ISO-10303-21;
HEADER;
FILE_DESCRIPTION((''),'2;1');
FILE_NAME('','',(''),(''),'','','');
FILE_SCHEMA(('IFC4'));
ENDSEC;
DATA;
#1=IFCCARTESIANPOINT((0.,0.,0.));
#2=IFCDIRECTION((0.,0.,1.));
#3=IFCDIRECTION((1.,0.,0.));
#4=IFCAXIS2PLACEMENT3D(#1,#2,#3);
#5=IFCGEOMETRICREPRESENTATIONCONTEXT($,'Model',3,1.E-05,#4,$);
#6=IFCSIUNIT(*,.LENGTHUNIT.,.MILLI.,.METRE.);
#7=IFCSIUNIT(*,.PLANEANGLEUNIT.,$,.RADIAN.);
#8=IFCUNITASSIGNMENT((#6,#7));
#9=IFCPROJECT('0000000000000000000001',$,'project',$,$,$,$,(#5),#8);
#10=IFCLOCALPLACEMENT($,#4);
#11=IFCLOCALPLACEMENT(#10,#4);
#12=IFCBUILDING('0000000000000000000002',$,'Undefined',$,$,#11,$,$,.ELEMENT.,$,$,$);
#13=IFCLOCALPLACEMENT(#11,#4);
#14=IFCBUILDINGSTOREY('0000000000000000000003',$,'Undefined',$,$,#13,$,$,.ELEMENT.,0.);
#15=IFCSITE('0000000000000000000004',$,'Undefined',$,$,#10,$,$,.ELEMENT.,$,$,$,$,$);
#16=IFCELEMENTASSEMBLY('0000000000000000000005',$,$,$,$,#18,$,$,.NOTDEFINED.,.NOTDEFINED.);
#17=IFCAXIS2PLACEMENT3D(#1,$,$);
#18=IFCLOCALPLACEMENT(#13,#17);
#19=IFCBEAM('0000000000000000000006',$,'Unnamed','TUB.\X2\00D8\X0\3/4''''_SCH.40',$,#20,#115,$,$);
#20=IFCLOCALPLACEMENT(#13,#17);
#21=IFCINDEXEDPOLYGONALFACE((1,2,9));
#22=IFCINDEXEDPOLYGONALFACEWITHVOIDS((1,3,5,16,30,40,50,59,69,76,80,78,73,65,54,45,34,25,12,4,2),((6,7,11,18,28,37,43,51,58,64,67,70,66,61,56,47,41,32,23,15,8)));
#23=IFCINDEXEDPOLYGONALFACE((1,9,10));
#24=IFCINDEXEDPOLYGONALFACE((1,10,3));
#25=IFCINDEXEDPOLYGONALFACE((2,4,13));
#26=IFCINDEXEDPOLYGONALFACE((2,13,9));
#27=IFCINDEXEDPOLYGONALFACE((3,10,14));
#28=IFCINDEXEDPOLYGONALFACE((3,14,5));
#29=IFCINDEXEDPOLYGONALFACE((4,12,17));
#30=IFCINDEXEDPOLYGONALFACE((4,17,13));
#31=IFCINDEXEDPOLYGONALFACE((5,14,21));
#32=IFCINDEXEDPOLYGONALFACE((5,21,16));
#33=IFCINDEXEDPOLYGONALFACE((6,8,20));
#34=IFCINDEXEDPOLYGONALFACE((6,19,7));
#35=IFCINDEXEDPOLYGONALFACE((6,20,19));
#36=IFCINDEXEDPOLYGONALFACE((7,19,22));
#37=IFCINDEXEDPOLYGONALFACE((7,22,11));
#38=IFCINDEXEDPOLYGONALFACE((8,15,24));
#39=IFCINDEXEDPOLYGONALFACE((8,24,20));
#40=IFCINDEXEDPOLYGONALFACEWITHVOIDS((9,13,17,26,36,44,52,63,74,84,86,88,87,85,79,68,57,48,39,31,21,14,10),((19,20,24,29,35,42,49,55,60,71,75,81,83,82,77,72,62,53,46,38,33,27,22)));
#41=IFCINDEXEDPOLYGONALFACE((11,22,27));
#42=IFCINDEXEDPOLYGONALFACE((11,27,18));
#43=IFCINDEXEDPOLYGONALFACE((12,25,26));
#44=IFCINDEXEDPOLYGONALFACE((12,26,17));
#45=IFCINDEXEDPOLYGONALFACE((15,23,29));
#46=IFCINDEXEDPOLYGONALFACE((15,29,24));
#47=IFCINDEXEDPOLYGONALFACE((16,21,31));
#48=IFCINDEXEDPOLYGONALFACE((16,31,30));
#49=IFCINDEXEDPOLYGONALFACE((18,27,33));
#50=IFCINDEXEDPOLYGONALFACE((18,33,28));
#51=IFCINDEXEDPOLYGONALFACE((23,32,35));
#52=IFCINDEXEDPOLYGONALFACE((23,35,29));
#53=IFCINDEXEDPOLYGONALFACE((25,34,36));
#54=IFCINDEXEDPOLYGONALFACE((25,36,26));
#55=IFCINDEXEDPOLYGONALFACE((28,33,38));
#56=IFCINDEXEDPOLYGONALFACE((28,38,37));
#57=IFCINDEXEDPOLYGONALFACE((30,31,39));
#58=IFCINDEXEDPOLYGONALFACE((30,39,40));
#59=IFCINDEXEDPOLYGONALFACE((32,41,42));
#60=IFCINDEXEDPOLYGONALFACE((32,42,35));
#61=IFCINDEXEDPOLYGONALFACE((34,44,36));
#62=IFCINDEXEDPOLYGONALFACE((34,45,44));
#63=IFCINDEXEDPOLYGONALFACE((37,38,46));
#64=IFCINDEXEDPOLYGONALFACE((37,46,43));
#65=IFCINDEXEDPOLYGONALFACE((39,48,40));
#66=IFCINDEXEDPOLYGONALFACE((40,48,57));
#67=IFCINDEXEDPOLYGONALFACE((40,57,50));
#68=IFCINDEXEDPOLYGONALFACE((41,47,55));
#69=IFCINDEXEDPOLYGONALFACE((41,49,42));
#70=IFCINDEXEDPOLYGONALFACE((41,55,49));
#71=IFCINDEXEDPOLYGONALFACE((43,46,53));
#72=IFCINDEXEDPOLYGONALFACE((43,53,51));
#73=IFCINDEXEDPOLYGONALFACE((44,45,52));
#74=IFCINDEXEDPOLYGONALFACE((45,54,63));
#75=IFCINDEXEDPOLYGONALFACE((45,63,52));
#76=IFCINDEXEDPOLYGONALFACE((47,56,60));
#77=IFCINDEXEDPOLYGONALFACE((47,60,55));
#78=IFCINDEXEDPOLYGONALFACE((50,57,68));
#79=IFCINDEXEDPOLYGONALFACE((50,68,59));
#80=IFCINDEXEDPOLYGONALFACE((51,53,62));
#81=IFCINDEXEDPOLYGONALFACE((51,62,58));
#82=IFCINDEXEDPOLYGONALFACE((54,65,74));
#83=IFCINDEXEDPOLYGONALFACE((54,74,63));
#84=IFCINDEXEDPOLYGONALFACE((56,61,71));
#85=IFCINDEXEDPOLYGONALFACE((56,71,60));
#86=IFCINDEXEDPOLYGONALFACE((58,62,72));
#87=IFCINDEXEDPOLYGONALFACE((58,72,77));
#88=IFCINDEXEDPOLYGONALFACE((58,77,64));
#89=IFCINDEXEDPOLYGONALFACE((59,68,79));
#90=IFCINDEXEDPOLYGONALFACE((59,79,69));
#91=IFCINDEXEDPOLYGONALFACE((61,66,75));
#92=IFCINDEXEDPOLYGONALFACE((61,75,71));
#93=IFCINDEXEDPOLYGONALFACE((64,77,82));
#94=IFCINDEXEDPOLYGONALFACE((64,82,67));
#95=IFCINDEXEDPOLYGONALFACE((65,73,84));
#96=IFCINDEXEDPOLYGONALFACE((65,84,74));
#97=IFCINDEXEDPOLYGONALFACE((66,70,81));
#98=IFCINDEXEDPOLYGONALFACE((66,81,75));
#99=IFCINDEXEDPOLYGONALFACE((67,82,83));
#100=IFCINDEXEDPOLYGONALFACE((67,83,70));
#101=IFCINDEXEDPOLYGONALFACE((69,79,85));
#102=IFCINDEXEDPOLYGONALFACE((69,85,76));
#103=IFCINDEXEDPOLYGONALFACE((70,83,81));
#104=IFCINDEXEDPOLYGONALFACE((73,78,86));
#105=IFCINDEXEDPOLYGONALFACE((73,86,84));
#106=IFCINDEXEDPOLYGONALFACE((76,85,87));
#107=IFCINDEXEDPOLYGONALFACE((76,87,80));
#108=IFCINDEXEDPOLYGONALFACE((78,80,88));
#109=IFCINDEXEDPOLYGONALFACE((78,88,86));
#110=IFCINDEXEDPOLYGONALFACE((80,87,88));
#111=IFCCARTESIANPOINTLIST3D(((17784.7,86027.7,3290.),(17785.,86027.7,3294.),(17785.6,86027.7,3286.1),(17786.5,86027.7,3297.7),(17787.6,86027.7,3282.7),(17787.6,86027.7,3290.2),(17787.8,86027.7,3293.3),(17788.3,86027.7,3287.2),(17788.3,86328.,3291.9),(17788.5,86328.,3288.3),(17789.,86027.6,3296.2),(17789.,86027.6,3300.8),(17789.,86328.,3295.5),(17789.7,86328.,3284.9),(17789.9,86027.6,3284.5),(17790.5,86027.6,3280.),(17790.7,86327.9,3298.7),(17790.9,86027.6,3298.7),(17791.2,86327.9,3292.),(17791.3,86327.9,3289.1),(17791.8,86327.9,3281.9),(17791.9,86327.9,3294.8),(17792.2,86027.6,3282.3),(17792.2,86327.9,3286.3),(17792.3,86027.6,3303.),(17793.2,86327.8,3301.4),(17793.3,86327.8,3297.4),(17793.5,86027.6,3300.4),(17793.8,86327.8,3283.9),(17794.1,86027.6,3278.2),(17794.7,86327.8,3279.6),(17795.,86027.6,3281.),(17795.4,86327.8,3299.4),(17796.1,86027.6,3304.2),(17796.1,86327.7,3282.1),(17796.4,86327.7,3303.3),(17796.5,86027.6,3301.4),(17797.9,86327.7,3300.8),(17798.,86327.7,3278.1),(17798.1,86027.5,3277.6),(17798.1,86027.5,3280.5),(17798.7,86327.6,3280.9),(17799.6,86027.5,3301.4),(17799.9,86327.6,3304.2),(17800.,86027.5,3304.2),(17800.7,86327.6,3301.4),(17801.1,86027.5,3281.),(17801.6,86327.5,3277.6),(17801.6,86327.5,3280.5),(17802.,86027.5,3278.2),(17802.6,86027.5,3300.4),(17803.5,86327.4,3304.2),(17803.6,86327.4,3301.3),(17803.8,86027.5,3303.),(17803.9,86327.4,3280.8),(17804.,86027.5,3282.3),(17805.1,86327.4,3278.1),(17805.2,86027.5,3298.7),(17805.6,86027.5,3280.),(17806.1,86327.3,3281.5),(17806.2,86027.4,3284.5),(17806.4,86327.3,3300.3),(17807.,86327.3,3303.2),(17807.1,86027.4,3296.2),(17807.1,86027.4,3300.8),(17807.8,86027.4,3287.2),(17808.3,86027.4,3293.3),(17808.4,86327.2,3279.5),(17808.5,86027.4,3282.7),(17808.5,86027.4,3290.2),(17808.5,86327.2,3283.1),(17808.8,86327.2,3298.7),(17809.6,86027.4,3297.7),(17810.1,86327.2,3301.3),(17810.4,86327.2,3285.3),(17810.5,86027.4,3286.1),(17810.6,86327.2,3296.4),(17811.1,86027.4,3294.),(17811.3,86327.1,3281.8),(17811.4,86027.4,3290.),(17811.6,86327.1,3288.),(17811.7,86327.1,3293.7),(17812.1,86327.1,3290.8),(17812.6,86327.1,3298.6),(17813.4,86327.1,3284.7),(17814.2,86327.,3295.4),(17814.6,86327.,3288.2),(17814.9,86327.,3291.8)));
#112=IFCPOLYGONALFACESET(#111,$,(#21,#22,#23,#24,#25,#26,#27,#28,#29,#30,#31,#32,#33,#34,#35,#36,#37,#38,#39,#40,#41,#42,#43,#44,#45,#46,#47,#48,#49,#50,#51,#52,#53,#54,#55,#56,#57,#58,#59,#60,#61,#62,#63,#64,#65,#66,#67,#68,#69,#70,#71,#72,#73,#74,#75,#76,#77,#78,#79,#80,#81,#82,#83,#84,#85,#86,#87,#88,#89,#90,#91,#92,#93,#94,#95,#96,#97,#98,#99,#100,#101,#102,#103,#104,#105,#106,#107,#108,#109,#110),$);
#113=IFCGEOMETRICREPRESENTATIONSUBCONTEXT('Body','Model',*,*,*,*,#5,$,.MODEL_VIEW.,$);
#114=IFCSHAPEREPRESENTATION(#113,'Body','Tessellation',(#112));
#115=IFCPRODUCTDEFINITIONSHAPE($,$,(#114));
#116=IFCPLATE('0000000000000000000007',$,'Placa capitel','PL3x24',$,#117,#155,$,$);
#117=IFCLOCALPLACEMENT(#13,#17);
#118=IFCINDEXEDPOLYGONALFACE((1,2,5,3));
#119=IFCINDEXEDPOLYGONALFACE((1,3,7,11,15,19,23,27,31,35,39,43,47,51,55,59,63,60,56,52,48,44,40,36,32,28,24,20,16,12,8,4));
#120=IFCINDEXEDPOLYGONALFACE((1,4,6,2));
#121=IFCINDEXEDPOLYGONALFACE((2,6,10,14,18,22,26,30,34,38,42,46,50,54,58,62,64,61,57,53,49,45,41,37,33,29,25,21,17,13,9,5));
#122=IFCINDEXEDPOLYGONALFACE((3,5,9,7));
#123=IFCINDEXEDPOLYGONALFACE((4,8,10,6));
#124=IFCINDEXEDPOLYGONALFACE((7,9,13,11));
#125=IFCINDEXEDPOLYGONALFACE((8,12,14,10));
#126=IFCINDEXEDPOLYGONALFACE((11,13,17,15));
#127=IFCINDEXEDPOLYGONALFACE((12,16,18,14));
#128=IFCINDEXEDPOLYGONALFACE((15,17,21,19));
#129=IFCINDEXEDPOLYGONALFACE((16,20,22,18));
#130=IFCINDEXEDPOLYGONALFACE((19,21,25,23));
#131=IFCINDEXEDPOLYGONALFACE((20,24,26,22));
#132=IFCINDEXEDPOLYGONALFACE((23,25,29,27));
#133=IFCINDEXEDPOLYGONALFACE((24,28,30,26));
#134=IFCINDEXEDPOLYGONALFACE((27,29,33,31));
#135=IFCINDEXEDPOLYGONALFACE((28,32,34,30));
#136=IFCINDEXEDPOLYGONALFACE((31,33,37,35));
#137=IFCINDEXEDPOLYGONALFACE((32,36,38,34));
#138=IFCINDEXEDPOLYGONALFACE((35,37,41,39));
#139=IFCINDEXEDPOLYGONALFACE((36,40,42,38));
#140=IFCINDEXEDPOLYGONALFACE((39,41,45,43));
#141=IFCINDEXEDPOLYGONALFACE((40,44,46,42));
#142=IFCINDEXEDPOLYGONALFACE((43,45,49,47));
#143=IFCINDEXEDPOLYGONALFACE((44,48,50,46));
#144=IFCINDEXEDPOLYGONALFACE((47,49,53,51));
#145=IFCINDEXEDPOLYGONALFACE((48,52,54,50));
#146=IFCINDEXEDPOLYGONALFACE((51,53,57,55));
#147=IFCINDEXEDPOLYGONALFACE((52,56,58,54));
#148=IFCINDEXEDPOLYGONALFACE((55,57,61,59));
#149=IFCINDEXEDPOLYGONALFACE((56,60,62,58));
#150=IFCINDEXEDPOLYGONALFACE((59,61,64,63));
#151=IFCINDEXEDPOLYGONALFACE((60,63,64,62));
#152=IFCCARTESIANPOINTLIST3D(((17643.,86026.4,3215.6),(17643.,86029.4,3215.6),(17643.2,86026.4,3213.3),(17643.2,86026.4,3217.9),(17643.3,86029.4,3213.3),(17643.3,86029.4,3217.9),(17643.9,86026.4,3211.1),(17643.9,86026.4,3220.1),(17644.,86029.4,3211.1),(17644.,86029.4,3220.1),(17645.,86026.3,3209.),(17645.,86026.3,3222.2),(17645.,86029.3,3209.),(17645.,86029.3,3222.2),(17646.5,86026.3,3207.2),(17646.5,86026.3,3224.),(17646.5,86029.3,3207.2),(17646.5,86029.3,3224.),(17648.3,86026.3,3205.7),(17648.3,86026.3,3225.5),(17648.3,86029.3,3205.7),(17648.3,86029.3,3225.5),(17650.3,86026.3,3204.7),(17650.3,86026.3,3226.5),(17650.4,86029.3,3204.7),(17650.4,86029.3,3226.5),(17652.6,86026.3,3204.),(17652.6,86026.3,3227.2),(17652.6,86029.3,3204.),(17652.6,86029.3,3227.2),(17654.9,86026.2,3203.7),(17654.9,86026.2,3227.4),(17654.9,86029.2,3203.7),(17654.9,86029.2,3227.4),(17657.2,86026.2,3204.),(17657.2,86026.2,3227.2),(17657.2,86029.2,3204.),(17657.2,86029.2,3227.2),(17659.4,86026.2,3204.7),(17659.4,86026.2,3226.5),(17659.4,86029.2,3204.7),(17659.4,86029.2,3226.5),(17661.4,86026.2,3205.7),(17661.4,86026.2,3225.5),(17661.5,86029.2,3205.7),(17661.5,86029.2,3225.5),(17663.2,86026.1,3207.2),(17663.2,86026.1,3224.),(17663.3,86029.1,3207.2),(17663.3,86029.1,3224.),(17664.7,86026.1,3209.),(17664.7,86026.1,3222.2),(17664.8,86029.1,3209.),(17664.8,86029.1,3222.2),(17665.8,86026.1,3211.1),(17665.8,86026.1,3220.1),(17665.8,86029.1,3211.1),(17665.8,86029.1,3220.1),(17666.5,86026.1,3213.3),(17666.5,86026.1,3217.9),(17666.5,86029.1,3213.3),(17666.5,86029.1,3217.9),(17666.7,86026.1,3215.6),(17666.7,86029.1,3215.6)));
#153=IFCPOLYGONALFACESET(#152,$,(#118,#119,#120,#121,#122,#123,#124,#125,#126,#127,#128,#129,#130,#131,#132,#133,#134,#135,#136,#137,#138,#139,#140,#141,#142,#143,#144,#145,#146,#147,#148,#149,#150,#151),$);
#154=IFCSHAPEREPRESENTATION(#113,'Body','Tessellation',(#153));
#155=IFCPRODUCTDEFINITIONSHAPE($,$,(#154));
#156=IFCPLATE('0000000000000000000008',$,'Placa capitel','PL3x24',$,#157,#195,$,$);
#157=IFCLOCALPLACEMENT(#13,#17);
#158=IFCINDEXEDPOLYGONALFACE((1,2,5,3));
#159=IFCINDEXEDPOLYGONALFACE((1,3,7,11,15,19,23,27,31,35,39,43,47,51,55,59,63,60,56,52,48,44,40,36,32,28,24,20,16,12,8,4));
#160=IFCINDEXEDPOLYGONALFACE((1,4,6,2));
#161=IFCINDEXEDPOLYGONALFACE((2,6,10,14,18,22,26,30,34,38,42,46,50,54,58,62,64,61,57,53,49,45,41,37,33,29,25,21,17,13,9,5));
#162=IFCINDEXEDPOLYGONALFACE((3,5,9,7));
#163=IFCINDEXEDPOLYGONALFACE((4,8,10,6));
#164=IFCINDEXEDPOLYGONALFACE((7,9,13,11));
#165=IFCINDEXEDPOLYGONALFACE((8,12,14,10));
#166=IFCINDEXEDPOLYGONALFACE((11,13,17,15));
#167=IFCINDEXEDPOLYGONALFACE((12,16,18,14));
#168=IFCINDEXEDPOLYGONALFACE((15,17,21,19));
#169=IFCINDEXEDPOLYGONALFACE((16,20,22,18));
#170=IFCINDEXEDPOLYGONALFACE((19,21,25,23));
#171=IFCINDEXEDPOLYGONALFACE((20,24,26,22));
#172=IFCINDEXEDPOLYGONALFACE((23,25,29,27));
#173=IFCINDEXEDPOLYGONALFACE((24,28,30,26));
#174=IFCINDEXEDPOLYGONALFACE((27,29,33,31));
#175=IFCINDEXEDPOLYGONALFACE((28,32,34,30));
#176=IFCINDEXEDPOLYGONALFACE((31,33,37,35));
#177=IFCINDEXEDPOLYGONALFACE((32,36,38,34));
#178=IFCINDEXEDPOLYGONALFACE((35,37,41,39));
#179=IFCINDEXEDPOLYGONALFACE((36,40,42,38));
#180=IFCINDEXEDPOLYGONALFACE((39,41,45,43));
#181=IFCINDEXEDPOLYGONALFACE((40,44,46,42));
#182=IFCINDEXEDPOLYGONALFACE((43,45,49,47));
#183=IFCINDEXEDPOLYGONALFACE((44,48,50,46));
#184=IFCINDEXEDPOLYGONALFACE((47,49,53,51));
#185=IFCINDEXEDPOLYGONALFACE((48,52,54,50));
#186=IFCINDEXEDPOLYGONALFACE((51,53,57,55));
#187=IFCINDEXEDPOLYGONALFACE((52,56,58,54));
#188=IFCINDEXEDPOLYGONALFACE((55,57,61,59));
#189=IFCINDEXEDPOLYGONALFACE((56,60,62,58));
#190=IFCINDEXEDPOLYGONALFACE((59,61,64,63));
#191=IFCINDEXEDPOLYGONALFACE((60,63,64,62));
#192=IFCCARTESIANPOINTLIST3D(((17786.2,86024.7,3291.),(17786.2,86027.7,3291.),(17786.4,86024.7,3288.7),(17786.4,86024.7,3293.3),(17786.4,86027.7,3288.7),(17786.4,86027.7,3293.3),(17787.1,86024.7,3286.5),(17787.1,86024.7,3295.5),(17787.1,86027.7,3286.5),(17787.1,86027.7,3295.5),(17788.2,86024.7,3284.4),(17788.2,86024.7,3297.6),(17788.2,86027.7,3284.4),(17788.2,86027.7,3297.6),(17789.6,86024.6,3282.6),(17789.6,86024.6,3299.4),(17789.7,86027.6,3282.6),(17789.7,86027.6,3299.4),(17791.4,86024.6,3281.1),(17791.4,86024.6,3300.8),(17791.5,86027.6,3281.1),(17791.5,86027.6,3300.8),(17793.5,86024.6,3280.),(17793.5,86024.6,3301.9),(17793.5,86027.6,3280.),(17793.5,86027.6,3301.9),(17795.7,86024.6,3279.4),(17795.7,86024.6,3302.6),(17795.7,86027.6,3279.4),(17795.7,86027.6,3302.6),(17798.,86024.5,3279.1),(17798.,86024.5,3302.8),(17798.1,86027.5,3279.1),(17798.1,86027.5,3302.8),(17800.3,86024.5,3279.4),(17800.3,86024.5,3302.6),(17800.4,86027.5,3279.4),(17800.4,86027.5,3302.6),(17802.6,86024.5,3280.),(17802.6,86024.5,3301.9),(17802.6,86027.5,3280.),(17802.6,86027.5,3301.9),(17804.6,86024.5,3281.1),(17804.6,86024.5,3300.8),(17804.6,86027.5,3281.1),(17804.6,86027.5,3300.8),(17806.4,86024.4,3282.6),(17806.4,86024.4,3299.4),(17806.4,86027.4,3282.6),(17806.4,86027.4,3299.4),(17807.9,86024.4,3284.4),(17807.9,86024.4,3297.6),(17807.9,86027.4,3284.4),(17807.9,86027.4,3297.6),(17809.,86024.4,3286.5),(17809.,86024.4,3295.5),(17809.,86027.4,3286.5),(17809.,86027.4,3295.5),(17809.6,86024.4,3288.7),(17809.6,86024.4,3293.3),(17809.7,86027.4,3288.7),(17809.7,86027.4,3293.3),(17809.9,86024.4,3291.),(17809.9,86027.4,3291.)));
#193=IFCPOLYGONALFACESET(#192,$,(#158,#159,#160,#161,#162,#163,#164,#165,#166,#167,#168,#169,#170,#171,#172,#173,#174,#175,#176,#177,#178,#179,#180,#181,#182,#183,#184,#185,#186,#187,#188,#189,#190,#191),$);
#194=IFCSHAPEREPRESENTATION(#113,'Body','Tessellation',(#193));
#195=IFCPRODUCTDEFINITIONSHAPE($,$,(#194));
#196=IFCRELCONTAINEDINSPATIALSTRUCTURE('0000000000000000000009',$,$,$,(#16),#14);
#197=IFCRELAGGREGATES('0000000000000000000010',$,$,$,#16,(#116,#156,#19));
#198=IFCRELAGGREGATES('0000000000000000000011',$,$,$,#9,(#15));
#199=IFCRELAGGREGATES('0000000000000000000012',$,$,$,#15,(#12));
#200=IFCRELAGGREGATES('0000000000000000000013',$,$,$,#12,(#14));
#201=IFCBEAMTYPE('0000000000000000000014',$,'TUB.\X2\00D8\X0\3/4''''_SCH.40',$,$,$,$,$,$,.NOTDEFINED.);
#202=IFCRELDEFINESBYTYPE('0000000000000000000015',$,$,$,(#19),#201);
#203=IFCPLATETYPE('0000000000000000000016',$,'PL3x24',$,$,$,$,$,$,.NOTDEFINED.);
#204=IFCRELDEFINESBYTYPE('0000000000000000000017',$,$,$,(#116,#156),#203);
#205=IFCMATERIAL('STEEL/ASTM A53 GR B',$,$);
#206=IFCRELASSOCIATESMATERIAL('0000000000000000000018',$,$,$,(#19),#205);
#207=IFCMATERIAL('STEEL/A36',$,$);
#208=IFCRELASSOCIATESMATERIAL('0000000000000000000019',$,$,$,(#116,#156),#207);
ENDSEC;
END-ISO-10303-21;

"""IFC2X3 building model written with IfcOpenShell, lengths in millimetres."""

from ifc_helpers import new_model, si_unit, frame, origin_with_axes, origin_2d_with_axis, place, context, subcontext, project, spatial, polyline, hollow_circle, outline, extrude, clip, halfspace, material, type_object, element, aggregate, save


model = new_model("IFC2X3")

# Units and contexts
model_context = context("Model", 3, precision=1e-05, world=origin_with_axes())
body_context = subcontext(model_context, "Body", "Model", "MODEL_VIEW")
ifc_project = project(units=[si_unit("LENGTHUNIT", "METRE", prefix="MILLI"), si_unit("PLANEANGLEUNIT", "RADIAN")], contexts=[model_context])

# Site, building, storey
site_placement = place(None, origin_with_axes())
site = spatial("IfcSite", under=ifc_project, at=site_placement, Name="Undefined", CompositionType="ELEMENT")
building_placement = place(site_placement, origin_with_axes())
building = spatial("IfcBuilding", under=site, at=building_placement, Name="Undefined", CompositionType="ELEMENT")
storey_placement = place(building_placement, origin_with_axes())
storey = spatial("IfcBuildingStorey", under=building, at=storey_placement, Name="Undefined", CompositionType="ELEMENT", Elevation=0.0)

# Element assembly, beam, plates
assembly_placement = place(storey_placement, origin_with_axes())
assembly = element("IfcElementAssembly", 1, at=assembly_placement, inside=storey, AssemblyPlace="NOTDEFINED", PredefinedType="NOTDEFINED")
ifc_material_1 = material(Name="STEEL/ASTM A53 GR B")
beam_type_1 = type_object("IfcBeamType", Name="TUB.Ø3/4''_SCH.40", PredefinedType="NOTDEFINED")
beam_1_placement = place(assembly_placement, frame((17801.6, 86327.5, 3291.0), z_axis=(-0.99993, 0.011839, 0.0), x_axis=(-0.011839, -0.99993, 0.0)))
beam_1 = element("IfcBeam", 2, at=beam_1_placement, type_object=beam_type_1, material=ifc_material_1, Name="Unnamed", Description="TUB.Ø3/4''_SCH.40", context=body_context, shape_type="Clipping", body=[
    clip(clip(extrude(hollow_circle(Radius=13.3, WallThickness=2.9, at=origin_2d_with_axis()), frame((301.0, 0.0, 0.0), z_axis=(-1.0, 0.0, 0.0), x_axis=(0.0, -1.0, 0.0)), (0.0, 0.0, 1.0), 302.0), halfspace(frame((300.0, -13.3, 0.0), z_axis=(-1.0, 0.0, 0.0), x_axis=(0.0, 0.0, -1.0)), True)), halfspace(frame((0.4, 0.0, -13.4), z_axis=(-0.999617, 0.0, -0.027664), x_axis=(0.0, 1.0, 0.0)), False)),
])
ifc_material_2 = material(Name="STEEL/A36")
plate_type_1 = type_object("IfcPlateType", Name="PL3x24", PredefinedType="NOTDEFINED")
plate_1_placement = place(assembly_placement, frame((17652.6, 86027.8, 3227.2), z_axis=(-0.011821, -0.99993, 0.0), x_axis=(-0.956873, 0.011312, -0.290285)))
plate_1 = element("IfcPlate", 3, at=plate_1_placement, type_object=plate_type_1, material=ifc_material_2, Name="Placa capitel", Description="PL3x24", context=body_context, shape_type="SweptSolid", body=[
    extrude(outline(polyline([(0.0, 0.0), (2.3, 0.0), (4.6, 0.5), (6.7, 1.3), (8.7, 2.6), (10.3, 4.3), (11.6, 6.2), (12.5, 8.4), (13.0, 10.6), (13.0, 13.0), (12.5, 15.2), (11.6, 17.4), (10.3, 19.3), (8.7, 21.0), (6.7, 22.2), (4.6, 23.1), (2.3, 23.6), (0.0, 23.6), (-2.3, 23.1), (-4.4, 22.2), (-6.4, 21.0), (-8.0, 19.3), (-9.3, 17.4), (-10.2, 15.2), (-10.6, 13.0), (-10.6, 10.6), (-10.2, 8.4), (-9.3, 6.2), (-8.0, 4.3), (-6.4, 2.6), (-4.4, 1.3), (-2.3, 0.5), (0.0, 0.0)])), frame((0.0, 0.0, -1.5), z_axis=(0.0, 0.0, 1.0), x_axis=(1.0, 0.0, 0.0)), (0.0, 0.0, 1.0), 3.0),
])
plate_2_placement = place(assembly_placement, frame((17795.7, 86026.1, 3302.6), z_axis=(-0.011839, -0.99993, 0.0), x_axis=(-0.956873, 0.011329, -0.290285)))
plate_2 = element("IfcPlate", 4, at=plate_2_placement, type_object=plate_type_1, material=ifc_material_2, Name="Placa capitel", Description="PL3x24", context=body_context, shape_type="SweptSolid", body=[
    extrude(outline(polyline([(0.0, 0.0), (2.3, 0.0), (4.6, 0.5), (6.7, 1.3), (8.7, 2.6), (10.3, 4.3), (11.6, 6.2), (12.5, 8.4), (13.0, 10.6), (13.0, 13.0), (12.5, 15.2), (11.6, 17.4), (10.3, 19.3), (8.7, 21.0), (6.7, 22.2), (4.6, 23.1), (2.3, 23.6), (0.0, 23.6), (-2.3, 23.1), (-4.4, 22.2), (-6.4, 21.0), (-8.0, 19.3), (-9.3, 17.4), (-10.2, 15.2), (-10.6, 13.0), (-10.6, 10.6), (-10.2, 8.4), (-9.3, 6.2), (-8.0, 4.3), (-6.4, 2.6), (-4.4, 1.3), (-2.3, 0.5), (0.0, 0.0)])), frame((0.0, 0.0, -1.5), z_axis=(0.0, 0.0, 1.0), x_axis=(1.0, 0.0, 0.0)), (0.0, 0.0, 1.0), 3.0),
])
aggregate(assembly, [plate_1, plate_2, beam_1])

save(model, "model.ifc")
